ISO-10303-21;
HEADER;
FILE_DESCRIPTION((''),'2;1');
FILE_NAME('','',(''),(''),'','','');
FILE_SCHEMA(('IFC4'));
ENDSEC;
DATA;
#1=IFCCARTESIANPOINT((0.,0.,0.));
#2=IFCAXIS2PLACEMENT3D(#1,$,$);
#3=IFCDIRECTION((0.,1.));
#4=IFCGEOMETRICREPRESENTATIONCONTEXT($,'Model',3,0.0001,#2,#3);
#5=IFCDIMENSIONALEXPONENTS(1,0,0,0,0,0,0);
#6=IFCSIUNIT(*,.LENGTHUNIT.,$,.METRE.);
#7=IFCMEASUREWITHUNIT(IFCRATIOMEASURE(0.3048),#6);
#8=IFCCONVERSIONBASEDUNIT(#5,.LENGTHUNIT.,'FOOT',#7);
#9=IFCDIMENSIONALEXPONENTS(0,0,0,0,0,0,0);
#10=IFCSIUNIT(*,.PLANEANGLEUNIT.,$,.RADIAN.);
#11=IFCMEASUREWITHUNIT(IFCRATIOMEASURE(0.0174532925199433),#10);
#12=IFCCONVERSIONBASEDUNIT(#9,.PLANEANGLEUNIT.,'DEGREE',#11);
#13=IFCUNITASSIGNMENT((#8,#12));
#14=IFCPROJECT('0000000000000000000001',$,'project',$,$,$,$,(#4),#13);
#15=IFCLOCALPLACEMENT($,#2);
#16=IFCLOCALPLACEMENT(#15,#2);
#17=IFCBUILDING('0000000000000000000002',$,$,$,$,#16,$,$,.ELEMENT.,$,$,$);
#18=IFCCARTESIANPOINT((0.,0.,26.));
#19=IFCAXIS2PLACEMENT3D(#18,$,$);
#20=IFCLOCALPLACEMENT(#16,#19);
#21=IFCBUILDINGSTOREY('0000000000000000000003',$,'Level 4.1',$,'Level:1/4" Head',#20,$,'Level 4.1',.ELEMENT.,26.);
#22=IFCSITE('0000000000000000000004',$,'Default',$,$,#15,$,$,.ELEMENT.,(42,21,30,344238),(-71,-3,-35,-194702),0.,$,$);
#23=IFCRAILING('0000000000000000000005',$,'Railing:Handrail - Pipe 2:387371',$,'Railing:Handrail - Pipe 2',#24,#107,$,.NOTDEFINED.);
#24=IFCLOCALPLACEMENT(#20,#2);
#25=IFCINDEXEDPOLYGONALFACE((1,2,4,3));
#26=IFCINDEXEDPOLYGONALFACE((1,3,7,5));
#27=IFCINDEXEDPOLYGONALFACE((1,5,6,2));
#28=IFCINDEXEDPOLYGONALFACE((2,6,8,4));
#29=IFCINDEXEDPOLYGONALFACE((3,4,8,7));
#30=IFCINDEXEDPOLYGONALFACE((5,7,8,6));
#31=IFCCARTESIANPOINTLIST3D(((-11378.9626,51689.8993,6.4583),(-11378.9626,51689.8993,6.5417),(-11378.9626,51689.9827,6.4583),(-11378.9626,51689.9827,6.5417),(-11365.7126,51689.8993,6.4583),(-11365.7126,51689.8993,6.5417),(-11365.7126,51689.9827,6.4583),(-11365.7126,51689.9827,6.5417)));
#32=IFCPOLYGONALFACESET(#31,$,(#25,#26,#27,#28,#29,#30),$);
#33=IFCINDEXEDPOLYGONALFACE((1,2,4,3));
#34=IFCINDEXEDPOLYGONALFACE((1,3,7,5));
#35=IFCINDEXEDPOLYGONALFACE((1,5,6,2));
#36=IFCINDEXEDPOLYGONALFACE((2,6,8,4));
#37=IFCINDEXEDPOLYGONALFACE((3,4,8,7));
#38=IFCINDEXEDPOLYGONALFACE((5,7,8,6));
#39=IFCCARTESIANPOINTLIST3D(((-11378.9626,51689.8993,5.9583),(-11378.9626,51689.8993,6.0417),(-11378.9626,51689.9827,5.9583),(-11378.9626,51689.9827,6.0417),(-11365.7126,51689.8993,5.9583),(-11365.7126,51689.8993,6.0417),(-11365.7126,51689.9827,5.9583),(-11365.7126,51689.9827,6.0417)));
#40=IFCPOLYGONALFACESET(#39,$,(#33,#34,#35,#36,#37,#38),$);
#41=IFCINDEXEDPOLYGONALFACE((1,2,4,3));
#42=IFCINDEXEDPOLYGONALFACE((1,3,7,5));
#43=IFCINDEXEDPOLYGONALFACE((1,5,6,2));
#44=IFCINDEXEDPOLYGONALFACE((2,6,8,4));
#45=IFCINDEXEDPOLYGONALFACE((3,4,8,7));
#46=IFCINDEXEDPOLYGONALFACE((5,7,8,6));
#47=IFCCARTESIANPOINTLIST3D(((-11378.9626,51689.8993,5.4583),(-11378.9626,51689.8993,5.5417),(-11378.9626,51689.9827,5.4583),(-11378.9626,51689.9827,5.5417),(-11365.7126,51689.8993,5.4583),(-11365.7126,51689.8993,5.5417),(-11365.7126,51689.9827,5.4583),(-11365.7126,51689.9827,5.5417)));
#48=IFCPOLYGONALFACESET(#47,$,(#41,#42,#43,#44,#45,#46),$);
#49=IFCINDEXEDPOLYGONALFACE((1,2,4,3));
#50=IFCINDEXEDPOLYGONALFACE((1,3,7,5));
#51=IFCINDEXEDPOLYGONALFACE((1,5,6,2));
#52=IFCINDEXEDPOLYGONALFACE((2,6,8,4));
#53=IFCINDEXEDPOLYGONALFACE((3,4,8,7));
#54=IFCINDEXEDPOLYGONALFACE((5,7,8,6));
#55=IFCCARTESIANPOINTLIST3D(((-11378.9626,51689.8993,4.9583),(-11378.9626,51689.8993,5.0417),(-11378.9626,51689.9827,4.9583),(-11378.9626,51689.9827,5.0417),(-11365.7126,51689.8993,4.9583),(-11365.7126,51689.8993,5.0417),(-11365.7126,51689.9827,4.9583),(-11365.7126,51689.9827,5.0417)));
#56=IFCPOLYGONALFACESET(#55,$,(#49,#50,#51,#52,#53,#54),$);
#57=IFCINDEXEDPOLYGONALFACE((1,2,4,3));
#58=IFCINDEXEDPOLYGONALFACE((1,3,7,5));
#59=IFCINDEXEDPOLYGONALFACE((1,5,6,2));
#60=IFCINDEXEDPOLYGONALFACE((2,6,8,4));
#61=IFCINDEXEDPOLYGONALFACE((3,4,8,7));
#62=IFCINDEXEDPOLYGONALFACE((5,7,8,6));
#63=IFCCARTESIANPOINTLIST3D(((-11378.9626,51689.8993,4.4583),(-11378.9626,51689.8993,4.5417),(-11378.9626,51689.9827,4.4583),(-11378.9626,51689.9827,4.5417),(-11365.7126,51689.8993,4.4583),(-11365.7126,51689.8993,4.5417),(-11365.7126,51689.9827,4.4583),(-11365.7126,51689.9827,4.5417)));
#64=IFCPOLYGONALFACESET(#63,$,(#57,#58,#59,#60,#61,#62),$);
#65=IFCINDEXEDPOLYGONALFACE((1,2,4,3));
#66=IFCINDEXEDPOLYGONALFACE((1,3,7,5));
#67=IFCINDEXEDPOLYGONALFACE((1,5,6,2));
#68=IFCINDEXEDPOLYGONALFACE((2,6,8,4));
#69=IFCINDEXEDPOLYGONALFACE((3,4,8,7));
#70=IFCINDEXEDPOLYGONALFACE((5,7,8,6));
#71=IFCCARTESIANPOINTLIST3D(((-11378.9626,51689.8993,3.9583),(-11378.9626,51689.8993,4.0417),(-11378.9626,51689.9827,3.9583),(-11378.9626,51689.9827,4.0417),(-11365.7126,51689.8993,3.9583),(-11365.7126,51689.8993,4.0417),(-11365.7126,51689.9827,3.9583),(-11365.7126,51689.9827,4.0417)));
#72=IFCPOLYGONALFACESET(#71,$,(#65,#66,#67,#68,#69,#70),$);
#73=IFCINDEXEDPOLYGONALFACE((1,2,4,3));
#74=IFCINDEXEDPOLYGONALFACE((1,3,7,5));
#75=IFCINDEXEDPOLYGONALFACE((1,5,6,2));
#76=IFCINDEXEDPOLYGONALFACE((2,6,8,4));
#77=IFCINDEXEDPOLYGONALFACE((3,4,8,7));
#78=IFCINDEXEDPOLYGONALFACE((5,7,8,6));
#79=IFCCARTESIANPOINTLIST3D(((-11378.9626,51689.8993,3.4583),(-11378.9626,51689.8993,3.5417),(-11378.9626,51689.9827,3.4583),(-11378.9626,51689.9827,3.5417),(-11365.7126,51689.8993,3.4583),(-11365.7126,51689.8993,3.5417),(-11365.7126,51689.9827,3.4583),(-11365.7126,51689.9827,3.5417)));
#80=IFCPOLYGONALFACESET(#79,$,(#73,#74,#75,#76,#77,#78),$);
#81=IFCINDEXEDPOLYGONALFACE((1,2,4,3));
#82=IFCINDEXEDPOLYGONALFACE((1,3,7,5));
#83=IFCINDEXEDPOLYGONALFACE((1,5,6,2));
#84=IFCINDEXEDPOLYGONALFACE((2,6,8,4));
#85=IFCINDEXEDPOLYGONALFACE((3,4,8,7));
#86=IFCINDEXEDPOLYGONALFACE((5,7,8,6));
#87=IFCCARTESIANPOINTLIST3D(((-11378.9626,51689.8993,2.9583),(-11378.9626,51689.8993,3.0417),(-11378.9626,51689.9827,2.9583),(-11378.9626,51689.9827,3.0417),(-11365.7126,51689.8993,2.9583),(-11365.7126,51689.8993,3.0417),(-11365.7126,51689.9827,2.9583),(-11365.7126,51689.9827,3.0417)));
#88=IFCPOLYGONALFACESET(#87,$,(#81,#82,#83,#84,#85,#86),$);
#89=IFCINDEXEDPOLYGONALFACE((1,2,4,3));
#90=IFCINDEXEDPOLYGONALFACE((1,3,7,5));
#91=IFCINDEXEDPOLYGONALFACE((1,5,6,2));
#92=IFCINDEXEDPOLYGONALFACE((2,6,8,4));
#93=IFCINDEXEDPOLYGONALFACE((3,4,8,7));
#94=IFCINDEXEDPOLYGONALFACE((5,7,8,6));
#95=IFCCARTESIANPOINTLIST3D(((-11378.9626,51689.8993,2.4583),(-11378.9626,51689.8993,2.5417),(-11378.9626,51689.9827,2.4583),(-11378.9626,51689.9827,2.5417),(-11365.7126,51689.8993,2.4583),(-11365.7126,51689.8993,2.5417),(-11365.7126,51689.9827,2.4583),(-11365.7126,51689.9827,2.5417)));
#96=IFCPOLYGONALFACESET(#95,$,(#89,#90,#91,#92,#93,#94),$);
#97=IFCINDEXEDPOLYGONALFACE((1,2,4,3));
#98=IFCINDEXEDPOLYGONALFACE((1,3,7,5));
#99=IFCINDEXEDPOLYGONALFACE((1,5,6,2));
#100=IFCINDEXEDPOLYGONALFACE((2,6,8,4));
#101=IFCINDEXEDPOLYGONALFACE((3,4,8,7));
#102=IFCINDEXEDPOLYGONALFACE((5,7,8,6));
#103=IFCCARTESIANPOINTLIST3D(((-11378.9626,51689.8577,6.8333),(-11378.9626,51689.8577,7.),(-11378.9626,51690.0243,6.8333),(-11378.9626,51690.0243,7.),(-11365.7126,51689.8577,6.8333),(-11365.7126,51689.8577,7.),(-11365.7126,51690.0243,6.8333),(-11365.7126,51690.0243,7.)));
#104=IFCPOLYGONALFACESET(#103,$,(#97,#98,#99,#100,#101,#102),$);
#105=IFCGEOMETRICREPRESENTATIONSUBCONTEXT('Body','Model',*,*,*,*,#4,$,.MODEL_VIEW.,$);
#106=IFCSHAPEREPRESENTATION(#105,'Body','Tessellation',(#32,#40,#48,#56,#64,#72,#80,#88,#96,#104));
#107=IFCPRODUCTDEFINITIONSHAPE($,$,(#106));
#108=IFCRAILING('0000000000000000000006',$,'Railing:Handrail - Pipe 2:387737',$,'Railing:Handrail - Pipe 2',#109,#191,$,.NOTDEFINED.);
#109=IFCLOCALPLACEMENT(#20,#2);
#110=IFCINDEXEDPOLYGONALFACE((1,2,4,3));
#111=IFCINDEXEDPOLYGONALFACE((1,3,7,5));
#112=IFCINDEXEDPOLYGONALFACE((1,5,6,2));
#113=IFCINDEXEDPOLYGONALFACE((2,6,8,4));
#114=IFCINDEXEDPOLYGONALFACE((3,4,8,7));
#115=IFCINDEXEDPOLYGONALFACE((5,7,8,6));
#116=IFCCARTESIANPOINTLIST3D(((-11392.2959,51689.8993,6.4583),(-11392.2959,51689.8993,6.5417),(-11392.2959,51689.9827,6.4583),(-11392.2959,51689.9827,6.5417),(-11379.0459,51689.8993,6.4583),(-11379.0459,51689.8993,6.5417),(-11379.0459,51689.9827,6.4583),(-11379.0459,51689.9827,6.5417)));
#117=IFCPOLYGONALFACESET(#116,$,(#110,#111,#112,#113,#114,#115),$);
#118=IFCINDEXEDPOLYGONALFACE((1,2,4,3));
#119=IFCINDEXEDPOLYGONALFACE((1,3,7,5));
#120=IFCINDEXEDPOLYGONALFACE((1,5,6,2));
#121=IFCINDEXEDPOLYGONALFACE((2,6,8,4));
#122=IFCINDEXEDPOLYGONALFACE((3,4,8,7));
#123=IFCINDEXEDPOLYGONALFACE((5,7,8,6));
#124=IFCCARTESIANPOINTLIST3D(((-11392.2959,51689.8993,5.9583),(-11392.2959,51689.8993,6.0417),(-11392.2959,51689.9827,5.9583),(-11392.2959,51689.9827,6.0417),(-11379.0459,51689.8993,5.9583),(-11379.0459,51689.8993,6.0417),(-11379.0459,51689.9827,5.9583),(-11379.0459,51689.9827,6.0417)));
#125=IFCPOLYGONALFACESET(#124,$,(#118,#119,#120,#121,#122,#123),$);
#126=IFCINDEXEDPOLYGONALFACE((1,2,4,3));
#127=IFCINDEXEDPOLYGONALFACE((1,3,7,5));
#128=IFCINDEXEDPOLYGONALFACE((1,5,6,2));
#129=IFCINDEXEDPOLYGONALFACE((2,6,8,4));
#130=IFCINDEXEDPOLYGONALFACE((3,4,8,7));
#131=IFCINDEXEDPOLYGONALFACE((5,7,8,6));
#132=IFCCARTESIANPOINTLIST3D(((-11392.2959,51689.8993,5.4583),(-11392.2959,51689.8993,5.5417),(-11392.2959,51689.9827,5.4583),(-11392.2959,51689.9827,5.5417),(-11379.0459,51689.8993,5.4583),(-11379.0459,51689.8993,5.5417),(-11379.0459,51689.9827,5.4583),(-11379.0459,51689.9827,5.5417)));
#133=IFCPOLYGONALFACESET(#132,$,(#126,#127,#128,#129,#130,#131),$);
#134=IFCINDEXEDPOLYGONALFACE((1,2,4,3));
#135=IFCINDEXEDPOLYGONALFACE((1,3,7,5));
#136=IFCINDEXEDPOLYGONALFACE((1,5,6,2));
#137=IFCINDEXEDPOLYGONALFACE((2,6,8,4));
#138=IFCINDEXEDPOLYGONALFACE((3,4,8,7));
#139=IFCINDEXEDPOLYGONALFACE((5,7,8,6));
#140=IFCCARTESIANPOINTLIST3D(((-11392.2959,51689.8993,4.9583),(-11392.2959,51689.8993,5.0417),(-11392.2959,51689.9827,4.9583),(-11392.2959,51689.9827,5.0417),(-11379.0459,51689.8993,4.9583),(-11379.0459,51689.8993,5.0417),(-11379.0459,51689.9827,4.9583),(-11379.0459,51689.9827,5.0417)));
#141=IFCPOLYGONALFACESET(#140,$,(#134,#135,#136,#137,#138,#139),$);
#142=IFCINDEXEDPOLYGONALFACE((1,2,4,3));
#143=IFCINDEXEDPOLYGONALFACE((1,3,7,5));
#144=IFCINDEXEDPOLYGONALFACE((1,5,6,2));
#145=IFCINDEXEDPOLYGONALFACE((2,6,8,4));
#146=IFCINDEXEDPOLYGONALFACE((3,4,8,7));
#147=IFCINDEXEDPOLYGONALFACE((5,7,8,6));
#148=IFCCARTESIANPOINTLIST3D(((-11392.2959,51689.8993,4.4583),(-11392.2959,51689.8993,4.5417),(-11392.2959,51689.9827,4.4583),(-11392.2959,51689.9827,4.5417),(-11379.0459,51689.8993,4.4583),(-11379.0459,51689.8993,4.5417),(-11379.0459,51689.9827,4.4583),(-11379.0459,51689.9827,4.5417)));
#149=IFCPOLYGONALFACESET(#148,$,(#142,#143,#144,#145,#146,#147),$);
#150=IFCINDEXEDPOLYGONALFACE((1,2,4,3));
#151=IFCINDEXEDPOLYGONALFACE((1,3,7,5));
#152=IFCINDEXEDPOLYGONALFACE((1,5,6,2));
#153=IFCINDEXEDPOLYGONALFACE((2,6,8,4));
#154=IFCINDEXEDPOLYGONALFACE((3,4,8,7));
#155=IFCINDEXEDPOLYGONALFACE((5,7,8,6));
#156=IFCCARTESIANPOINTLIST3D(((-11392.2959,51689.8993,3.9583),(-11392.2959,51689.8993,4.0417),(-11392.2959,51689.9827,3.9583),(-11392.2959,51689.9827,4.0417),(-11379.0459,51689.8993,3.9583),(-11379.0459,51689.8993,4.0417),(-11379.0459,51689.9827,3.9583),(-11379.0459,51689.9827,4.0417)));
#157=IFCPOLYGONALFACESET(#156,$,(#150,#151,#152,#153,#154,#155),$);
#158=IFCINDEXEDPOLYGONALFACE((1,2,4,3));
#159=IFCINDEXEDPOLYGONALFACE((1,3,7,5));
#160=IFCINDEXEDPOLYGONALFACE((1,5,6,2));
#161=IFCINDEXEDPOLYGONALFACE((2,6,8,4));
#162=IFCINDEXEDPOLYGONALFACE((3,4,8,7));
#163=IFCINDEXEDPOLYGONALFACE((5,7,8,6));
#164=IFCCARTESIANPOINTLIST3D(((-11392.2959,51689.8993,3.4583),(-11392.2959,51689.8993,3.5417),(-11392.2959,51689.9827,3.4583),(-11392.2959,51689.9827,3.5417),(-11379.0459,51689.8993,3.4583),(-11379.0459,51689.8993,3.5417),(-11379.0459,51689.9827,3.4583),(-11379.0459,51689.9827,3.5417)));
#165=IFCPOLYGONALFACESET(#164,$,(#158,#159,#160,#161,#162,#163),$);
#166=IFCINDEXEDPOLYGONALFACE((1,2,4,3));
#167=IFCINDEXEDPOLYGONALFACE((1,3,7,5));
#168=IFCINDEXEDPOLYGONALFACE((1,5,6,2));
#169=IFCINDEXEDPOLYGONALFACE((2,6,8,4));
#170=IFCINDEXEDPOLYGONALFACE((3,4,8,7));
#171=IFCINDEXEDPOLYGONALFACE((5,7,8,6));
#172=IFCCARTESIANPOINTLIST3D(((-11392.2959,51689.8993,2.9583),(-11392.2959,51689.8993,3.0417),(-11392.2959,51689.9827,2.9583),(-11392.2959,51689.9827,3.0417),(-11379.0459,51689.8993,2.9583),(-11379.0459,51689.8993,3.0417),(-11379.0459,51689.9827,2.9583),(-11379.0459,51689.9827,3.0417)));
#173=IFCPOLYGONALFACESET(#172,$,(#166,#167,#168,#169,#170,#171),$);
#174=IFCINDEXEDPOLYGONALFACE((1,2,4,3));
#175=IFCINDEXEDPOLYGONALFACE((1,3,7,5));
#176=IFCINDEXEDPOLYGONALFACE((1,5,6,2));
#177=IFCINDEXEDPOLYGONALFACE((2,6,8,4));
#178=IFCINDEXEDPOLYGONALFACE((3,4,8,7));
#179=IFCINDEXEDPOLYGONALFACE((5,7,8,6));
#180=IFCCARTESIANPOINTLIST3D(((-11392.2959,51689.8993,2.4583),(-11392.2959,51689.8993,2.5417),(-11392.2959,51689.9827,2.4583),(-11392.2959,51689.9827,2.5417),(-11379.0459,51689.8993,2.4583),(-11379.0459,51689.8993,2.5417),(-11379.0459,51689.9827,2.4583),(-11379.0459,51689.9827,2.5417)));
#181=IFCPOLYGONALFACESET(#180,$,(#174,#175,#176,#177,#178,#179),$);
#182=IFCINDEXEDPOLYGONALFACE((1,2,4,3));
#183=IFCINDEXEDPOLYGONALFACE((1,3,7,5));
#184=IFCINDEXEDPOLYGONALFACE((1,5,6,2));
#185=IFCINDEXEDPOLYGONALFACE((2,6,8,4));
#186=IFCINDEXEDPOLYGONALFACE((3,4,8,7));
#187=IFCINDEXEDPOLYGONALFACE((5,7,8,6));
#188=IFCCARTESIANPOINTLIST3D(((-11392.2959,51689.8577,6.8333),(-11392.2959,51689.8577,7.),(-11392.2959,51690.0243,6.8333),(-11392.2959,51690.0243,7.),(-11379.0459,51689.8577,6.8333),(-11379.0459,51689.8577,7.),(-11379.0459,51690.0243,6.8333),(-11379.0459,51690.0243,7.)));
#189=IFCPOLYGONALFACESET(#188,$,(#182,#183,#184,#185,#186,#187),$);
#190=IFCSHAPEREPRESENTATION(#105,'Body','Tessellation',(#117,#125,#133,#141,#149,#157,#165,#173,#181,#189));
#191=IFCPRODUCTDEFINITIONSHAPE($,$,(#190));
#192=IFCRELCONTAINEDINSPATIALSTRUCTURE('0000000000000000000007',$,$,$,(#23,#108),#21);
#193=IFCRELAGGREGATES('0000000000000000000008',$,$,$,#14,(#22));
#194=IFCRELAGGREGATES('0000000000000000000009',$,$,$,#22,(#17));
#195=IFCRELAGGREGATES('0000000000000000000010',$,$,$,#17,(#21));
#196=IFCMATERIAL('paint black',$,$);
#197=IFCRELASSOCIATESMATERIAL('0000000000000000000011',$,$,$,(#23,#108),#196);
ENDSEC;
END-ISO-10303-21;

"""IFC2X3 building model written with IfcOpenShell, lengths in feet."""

from ifc_helpers import new_model, entity, si_unit, converted_unit, direction, frame, frame_2d, origin, place, context, subcontext, project, spatial, rectangle, extrude, material, element, save


model = new_model("IFC2X3")

# Units and contexts
model_context = context("Model", 3, precision=0.0001, world=origin(), true_north=direction((0.0, 1.0)))
body_context = subcontext(model_context, "Body", "Model", "MODEL_VIEW")
ifc_project = project(units=[converted_unit("LENGTHUNIT", "FOOT", entity("IfcRatioMeasure", 0.3048), si_unit("LENGTHUNIT", "METRE"), dimensions=[1, 0, 0, 0, 0, 0, 0]), converted_unit("PLANEANGLEUNIT", "DEGREE", entity("IfcRatioMeasure", 0.0174532925199433), si_unit("PLANEANGLEUNIT", "RADIAN"), dimensions=[0, 0, 0, 0, 0, 0, 0])], contexts=[model_context])

# Site, building, storey
site_placement = place(None, origin())
site = spatial("IfcSite", under=ifc_project, at=site_placement, Name="Default", CompositionType="ELEMENT", RefLatitude=(42, 21, 30, 344238), RefLongitude=(-71, -3, -35, -194702), RefElevation=0.0)
building_placement = place(site_placement, origin())
building = spatial("IfcBuilding", under=site, at=building_placement, CompositionType="ELEMENT")
storey_placement = place(building_placement, frame((0.0, 0.0, 26.0)))
storey = spatial("IfcBuildingStorey", under=building, at=storey_placement, Name="Level 4.1", ObjectType="Level:1/4\" Head", LongName="Level 4.1", CompositionType="ELEMENT", Elevation=26.0)

# Railings
ifc_material_1 = material(Name="paint black")
railing_1_placement = place(storey_placement, origin())
element("IfcRailing", 1, at=railing_1_placement, inside=storey, material=ifc_material_1, Name="Railing:Handrail - Pipe 2:387371", ObjectType="Railing:Handrail - Pipe 2", PredefinedType="NOTDEFINED", context=body_context, shape_type="SweptSolid", body=[
    extrude(rectangle(XDim=13.25, YDim=0.0833, at=frame_2d((0.0, 0.0), x_axis=(1.0, 0.0))), frame((-11372.3376, 51689.941, 6.4583), z_axis=(0.0, 0.0, 1.0), x_axis=(-1.0, 0.0, 0.0)), (0.0, 0.0, 1.0), 0.0833),
    extrude(rectangle(XDim=13.25, YDim=0.0833, at=frame_2d((0.0, 0.0), x_axis=(1.0, 0.0))), frame((-11372.3376, 51689.941, 5.9583), z_axis=(0.0, 0.0, 1.0), x_axis=(-1.0, 0.0, 0.0)), (0.0, 0.0, 1.0), 0.0833),
    extrude(rectangle(XDim=13.25, YDim=0.0833, at=frame_2d((0.0, 0.0), x_axis=(1.0, 0.0))), frame((-11372.3376, 51689.941, 5.4583), z_axis=(0.0, 0.0, 1.0), x_axis=(-1.0, 0.0, 0.0)), (0.0, 0.0, 1.0), 0.0833),
    extrude(rectangle(XDim=13.25, YDim=0.0833, at=frame_2d((0.0, 0.0), x_axis=(1.0, 0.0))), frame((-11372.3376, 51689.941, 4.9583), z_axis=(0.0, 0.0, 1.0), x_axis=(-1.0, 0.0, 0.0)), (0.0, 0.0, 1.0), 0.0833),
    extrude(rectangle(XDim=13.25, YDim=0.0833, at=frame_2d((0.0, 0.0), x_axis=(1.0, 0.0))), frame((-11372.3376, 51689.941, 4.4583), z_axis=(0.0, 0.0, 1.0), x_axis=(-1.0, 0.0, 0.0)), (0.0, 0.0, 1.0), 0.0833),
    extrude(rectangle(XDim=13.25, YDim=0.0833, at=frame_2d((0.0, 0.0), x_axis=(1.0, 0.0))), frame((-11372.3376, 51689.941, 3.9583), z_axis=(0.0, 0.0, 1.0), x_axis=(-1.0, 0.0, 0.0)), (0.0, 0.0, 1.0), 0.0833),
    extrude(rectangle(XDim=13.25, YDim=0.0833, at=frame_2d((0.0, 0.0), x_axis=(1.0, 0.0))), frame((-11372.3376, 51689.941, 3.4583), z_axis=(0.0, 0.0, 1.0), x_axis=(-1.0, 0.0, 0.0)), (0.0, 0.0, 1.0), 0.0833),
    extrude(rectangle(XDim=13.25, YDim=0.0833, at=frame_2d((0.0, 0.0), x_axis=(1.0, 0.0))), frame((-11372.3376, 51689.941, 2.9583), z_axis=(0.0, 0.0, 1.0), x_axis=(-1.0, 0.0, 0.0)), (0.0, 0.0, 1.0), 0.0833),
    extrude(rectangle(XDim=13.25, YDim=0.0833, at=frame_2d((0.0, 0.0), x_axis=(1.0, 0.0))), frame((-11372.3376, 51689.941, 2.4583), z_axis=(0.0, 0.0, 1.0), x_axis=(-1.0, 0.0, 0.0)), (0.0, 0.0, 1.0), 0.0833),
    extrude(rectangle(XDim=13.25, YDim=0.1667, at=frame_2d((0.0, 0.0), x_axis=(1.0, 0.0))), frame((-11372.3376, 51689.941, 6.8333), z_axis=(0.0, 0.0, 1.0), x_axis=(-1.0, 0.0, 0.0)), (0.0, 0.0, 1.0), 0.1667),
])
railing_2_placement = place(storey_placement, origin())
element("IfcRailing", 2, at=railing_2_placement, inside=storey, material=ifc_material_1, Name="Railing:Handrail - Pipe 2:387737", ObjectType="Railing:Handrail - Pipe 2", PredefinedType="NOTDEFINED", context=body_context, shape_type="SweptSolid", body=[
    extrude(rectangle(XDim=13.25, YDim=0.0833, at=frame_2d((0.0, 0.0), x_axis=(1.0, 0.0))), frame((-11385.6709, 51689.941, 6.4583), z_axis=(0.0, 0.0, 1.0), x_axis=(-1.0, 0.0, 0.0)), (0.0, 0.0, 1.0), 0.0833),
    extrude(rectangle(XDim=13.25, YDim=0.0833, at=frame_2d((0.0, 0.0), x_axis=(1.0, 0.0))), frame((-11385.6709, 51689.941, 5.9583), z_axis=(0.0, 0.0, 1.0), x_axis=(-1.0, 0.0, 0.0)), (0.0, 0.0, 1.0), 0.0833),
    extrude(rectangle(XDim=13.25, YDim=0.0833, at=frame_2d((0.0, 0.0), x_axis=(1.0, 0.0))), frame((-11385.6709, 51689.941, 5.4583), z_axis=(0.0, 0.0, 1.0), x_axis=(-1.0, 0.0, 0.0)), (0.0, 0.0, 1.0), 0.0833),
    extrude(rectangle(XDim=13.25, YDim=0.0833, at=frame_2d((0.0, 0.0), x_axis=(1.0, 0.0))), frame((-11385.6709, 51689.941, 4.9583), z_axis=(0.0, 0.0, 1.0), x_axis=(-1.0, 0.0, 0.0)), (0.0, 0.0, 1.0), 0.0833),
    extrude(rectangle(XDim=13.25, YDim=0.0833, at=frame_2d((0.0, 0.0), x_axis=(1.0, 0.0))), frame((-11385.6709, 51689.941, 4.4583), z_axis=(0.0, 0.0, 1.0), x_axis=(-1.0, 0.0, 0.0)), (0.0, 0.0, 1.0), 0.0833),
    extrude(rectangle(XDim=13.25, YDim=0.0833, at=frame_2d((0.0, 0.0), x_axis=(1.0, 0.0))), frame((-11385.6709, 51689.941, 3.9583), z_axis=(0.0, 0.0, 1.0), x_axis=(-1.0, 0.0, 0.0)), (0.0, 0.0, 1.0), 0.0833),
    extrude(rectangle(XDim=13.25, YDim=0.0833, at=frame_2d((0.0, 0.0), x_axis=(1.0, 0.0))), frame((-11385.6709, 51689.941, 3.4583), z_axis=(0.0, 0.0, 1.0), x_axis=(-1.0, 0.0, 0.0)), (0.0, 0.0, 1.0), 0.0833),
    extrude(rectangle(XDim=13.25, YDim=0.0833, at=frame_2d((0.0, 0.0), x_axis=(1.0, 0.0))), frame((-11385.6709, 51689.941, 2.9583), z_axis=(0.0, 0.0, 1.0), x_axis=(-1.0, 0.0, 0.0)), (0.0, 0.0, 1.0), 0.0833),
    extrude(rectangle(XDim=13.25, YDim=0.0833, at=frame_2d((0.0, 0.0), x_axis=(1.0, 0.0))), frame((-11385.6709, 51689.941, 2.4583), z_axis=(0.0, 0.0, 1.0), x_axis=(-1.0, 0.0, 0.0)), (0.0, 0.0, 1.0), 0.0833),
    extrude(rectangle(XDim=13.25, YDim=0.1667, at=frame_2d((0.0, 0.0), x_axis=(1.0, 0.0))), frame((-11385.6709, 51689.941, 6.8333), z_axis=(0.0, 0.0, 1.0), x_axis=(-1.0, 0.0, 0.0)), (0.0, 0.0, 1.0), 0.1667),
])

save(model, "model.ifc")
